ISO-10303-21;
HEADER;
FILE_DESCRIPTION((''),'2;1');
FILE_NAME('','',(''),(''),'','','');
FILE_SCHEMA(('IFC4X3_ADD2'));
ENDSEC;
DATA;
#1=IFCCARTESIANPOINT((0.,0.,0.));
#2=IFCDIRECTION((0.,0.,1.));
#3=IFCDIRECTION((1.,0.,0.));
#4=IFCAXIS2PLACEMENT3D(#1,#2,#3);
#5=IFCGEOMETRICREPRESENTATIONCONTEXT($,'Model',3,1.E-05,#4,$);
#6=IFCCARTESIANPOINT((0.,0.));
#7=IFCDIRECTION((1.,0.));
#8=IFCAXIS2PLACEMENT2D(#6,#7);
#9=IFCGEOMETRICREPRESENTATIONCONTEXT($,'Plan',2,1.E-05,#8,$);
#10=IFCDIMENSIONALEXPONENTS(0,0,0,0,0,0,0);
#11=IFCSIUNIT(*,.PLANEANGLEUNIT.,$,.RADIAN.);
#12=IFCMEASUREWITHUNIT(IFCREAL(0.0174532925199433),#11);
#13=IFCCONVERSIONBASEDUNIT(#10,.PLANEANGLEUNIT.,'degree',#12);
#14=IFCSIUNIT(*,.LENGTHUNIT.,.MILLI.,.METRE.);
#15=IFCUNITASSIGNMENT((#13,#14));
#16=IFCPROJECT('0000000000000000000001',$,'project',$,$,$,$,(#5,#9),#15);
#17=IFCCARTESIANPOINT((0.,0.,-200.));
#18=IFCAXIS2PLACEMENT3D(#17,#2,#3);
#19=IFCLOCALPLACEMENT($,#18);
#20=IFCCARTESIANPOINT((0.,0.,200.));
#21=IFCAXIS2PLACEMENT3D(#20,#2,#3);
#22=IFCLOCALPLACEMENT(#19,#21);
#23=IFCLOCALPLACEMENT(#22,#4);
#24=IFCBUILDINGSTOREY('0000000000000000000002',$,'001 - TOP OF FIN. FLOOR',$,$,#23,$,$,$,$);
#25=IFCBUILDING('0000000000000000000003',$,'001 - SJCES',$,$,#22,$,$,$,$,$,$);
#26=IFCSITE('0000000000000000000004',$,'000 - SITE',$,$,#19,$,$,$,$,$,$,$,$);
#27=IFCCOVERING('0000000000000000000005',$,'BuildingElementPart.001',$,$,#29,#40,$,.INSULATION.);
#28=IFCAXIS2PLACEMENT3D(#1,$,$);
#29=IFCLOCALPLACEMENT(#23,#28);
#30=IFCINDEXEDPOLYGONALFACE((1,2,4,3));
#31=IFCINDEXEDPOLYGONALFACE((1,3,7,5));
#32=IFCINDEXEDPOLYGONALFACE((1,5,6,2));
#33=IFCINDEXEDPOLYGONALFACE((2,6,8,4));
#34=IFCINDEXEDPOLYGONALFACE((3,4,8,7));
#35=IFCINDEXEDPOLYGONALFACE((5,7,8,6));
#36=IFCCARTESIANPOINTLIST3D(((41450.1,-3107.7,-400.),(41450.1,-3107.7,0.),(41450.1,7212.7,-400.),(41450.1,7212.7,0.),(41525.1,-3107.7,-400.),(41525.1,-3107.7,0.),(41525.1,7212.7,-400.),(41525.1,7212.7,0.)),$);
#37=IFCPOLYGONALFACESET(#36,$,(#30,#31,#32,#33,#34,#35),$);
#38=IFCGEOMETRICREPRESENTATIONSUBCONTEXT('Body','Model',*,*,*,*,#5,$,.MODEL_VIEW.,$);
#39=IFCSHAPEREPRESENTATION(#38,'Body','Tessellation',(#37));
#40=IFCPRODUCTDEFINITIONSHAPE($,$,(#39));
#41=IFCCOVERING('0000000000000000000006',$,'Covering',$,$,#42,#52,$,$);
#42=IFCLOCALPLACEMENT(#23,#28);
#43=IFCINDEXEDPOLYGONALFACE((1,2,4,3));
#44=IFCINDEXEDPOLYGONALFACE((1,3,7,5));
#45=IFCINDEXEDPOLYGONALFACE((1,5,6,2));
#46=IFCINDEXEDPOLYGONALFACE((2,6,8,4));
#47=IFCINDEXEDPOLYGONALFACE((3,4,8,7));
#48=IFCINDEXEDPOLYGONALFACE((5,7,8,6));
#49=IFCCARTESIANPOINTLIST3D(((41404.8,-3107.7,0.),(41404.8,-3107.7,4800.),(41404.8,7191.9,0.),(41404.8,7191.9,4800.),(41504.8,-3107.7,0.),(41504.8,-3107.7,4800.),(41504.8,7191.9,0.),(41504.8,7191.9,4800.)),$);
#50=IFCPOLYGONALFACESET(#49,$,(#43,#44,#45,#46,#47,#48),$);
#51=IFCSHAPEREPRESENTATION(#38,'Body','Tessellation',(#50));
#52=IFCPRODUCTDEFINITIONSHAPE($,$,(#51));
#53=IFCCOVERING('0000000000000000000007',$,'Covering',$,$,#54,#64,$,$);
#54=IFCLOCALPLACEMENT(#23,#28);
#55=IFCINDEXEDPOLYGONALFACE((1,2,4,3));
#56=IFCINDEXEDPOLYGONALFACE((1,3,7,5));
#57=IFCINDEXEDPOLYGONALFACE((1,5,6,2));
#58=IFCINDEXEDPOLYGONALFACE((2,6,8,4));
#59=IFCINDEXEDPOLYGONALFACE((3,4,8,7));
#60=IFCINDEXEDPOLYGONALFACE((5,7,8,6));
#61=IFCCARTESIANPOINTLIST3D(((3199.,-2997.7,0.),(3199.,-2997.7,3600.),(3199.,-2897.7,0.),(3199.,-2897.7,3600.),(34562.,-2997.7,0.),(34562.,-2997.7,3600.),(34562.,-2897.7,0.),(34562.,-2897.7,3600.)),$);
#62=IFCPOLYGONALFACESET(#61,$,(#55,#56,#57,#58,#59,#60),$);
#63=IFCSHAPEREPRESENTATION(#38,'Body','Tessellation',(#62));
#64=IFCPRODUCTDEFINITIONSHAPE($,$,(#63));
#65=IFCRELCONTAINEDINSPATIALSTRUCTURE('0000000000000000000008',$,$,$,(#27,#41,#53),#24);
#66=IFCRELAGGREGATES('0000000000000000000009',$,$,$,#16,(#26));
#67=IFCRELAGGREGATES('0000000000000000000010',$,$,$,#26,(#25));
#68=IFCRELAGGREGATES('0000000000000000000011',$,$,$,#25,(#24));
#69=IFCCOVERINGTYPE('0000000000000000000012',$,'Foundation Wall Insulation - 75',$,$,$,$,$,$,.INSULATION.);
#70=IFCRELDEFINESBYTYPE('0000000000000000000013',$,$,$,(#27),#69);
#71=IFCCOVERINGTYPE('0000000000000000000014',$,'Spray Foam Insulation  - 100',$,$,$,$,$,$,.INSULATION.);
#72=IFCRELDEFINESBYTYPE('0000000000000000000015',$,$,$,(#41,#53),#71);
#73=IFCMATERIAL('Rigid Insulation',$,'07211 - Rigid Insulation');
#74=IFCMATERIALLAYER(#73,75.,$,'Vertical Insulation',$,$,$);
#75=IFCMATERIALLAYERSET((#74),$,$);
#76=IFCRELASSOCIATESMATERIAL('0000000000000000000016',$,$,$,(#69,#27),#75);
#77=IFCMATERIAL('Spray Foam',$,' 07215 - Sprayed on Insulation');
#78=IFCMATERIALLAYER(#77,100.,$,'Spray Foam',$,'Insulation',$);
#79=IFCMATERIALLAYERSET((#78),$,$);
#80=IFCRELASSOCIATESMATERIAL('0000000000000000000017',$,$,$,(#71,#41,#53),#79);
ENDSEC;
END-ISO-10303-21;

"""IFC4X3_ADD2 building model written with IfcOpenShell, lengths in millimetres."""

from ifc_helpers import new_model, entity, si_unit, converted_unit, frame, origin_with_axes, origin_2d_with_axis, place, context, subcontext, project, spatial, indexed_curve, outline, extrude, material, layer, layer_set, layer_usage, type_object, element, save


model = new_model("IFC4X3_ADD2")

# Units and contexts
model_context = context("Model", 3, precision=1e-05, world=origin_with_axes())
plan_context = context("Plan", 2, precision=1e-05, world=origin_2d_with_axis())
body_context_1 = subcontext(model_context, "Body", "Model", "MODEL_VIEW")
ifc_project = project(units=[converted_unit("PLANEANGLEUNIT", "degree", entity("IfcReal", 0.0174532925199433), si_unit("PLANEANGLEUNIT", "RADIAN"), dimensions=[0, 0, 0, 0, 0, 0, 0]), si_unit("LENGTHUNIT", "METRE", prefix="MILLI")], contexts=[model_context, plan_context])

# Site, building, storey
site_placement = place(None, frame((0.0, 0.0, -200.0), z_axis=(0.0, 0.0, 1.0), x_axis=(1.0, 0.0, 0.0)))
site = spatial("IfcSite", under=ifc_project, at=site_placement, Name="000 - SITE")
building_placement = place(site_placement, frame((0.0, 0.0, 200.0), z_axis=(0.0, 0.0, 1.0), x_axis=(1.0, 0.0, 0.0)))
building = spatial("IfcBuilding", under=site, at=building_placement, Name="001 - SJCES")
storey_placement = place(building_placement, origin_with_axes())
storey = spatial("IfcBuildingStorey", under=building, at=storey_placement, Name="001 - TOP OF FIN. FLOOR")

# Shared definitions
covering_1_placement = place(storey_placement, frame((34562.0, -2897.7, 0.0), z_axis=(0.0, 0.0, 1.0), x_axis=(-1.0, 0.0, 0.0)))

# Coverings
ifc_material_1 = material(Name="Rigid Insulation", Category="07211 - Rigid Insulation")
ifc_layer_1 = layer(ifc_material_1, 75.0, Name="Vertical Insulation")
ifc_layer_set_1 = layer_set([ifc_layer_1])
covering_type_1 = type_object("IfcCoveringType", Name="Foundation Wall Insulation - 75", PredefinedType="INSULATION", material=ifc_layer_set_1)
ifc_layer_usage_1 = layer_usage(ifc_layer_set_1, "AXIS2", "POSITIVE", 0.0)
covering_2_placement = place(storey_placement, frame((41525.1, -3107.7, -400.0), z_axis=(0.0, 0.0, 1.0), x_axis=(0.0, 1.0, 0.0)))
element("IfcCovering", 1, at=covering_2_placement, inside=storey, type_object=covering_type_1, material=ifc_layer_usage_1, Name="BuildingElementPart.001", PredefinedType="INSULATION", context=body_context_1, shape_type="SweptSolid", body=[
    extrude(outline(indexed_curve([(0.0, 0.0), (0.0, 75.0), (10320.4, 75.0), (10320.4, 0.0), (0.0, 0.0)], self_intersect=False)), origin_with_axes(), (0.0, 0.0, 1.0), 400.0),
])
ifc_material_2 = material(Name="Spray Foam", Category=" 07215 - Sprayed on Insulation")
ifc_layer_2 = layer(ifc_material_2, 100.0, Name="Spray Foam", Category="Insulation")
ifc_layer_set_2 = layer_set([ifc_layer_2])
ifc_layer_usage_2 = layer_usage(ifc_layer_set_2, "AXIS2", "POSITIVE", 0.0)
covering_type_2 = type_object("IfcCoveringType", Name="Spray Foam Insulation  - 100", PredefinedType="INSULATION", material=ifc_layer_set_2)
covering_3_placement = place(storey_placement, frame((41404.8, 7191.9, 0.0), z_axis=(0.0, 0.0, 1.0), x_axis=(-0.000001, -1.0, 0.0)))
element("IfcCovering", 2, at=covering_3_placement, inside=storey, type_object=covering_type_2, material=ifc_layer_usage_2, Name="Covering", context=body_context_1, shape_type="SweptSolid", body=[
    extrude(outline(indexed_curve([(0.0, 0.0), (0.0, 100.0), (10299.6, 100.0), (10299.6, 0.0), (0.0, 0.0)], self_intersect=False)), origin_with_axes(), (0.0, 0.0, 1.0), 4800.0),
])
ifc_layer_usage_3 = layer_usage(ifc_layer_set_2, "AXIS2", "POSITIVE", 0.0)
element("IfcCovering", 3, at=covering_1_placement, inside=storey, type_object=covering_type_2, material=ifc_layer_usage_3, Name="Covering", context=body_context_1, shape_type="SweptSolid", body=[
    extrude(outline(indexed_curve([(0.0, 0.0), (0.0, 100.0), (31363.0, 100.0), (31363.0, 0.0), (0.0, 0.0)], self_intersect=False)), origin_with_axes(), (0.0, 0.0, 1.0), 3600.0),
])

save(model, "model.ifc")
